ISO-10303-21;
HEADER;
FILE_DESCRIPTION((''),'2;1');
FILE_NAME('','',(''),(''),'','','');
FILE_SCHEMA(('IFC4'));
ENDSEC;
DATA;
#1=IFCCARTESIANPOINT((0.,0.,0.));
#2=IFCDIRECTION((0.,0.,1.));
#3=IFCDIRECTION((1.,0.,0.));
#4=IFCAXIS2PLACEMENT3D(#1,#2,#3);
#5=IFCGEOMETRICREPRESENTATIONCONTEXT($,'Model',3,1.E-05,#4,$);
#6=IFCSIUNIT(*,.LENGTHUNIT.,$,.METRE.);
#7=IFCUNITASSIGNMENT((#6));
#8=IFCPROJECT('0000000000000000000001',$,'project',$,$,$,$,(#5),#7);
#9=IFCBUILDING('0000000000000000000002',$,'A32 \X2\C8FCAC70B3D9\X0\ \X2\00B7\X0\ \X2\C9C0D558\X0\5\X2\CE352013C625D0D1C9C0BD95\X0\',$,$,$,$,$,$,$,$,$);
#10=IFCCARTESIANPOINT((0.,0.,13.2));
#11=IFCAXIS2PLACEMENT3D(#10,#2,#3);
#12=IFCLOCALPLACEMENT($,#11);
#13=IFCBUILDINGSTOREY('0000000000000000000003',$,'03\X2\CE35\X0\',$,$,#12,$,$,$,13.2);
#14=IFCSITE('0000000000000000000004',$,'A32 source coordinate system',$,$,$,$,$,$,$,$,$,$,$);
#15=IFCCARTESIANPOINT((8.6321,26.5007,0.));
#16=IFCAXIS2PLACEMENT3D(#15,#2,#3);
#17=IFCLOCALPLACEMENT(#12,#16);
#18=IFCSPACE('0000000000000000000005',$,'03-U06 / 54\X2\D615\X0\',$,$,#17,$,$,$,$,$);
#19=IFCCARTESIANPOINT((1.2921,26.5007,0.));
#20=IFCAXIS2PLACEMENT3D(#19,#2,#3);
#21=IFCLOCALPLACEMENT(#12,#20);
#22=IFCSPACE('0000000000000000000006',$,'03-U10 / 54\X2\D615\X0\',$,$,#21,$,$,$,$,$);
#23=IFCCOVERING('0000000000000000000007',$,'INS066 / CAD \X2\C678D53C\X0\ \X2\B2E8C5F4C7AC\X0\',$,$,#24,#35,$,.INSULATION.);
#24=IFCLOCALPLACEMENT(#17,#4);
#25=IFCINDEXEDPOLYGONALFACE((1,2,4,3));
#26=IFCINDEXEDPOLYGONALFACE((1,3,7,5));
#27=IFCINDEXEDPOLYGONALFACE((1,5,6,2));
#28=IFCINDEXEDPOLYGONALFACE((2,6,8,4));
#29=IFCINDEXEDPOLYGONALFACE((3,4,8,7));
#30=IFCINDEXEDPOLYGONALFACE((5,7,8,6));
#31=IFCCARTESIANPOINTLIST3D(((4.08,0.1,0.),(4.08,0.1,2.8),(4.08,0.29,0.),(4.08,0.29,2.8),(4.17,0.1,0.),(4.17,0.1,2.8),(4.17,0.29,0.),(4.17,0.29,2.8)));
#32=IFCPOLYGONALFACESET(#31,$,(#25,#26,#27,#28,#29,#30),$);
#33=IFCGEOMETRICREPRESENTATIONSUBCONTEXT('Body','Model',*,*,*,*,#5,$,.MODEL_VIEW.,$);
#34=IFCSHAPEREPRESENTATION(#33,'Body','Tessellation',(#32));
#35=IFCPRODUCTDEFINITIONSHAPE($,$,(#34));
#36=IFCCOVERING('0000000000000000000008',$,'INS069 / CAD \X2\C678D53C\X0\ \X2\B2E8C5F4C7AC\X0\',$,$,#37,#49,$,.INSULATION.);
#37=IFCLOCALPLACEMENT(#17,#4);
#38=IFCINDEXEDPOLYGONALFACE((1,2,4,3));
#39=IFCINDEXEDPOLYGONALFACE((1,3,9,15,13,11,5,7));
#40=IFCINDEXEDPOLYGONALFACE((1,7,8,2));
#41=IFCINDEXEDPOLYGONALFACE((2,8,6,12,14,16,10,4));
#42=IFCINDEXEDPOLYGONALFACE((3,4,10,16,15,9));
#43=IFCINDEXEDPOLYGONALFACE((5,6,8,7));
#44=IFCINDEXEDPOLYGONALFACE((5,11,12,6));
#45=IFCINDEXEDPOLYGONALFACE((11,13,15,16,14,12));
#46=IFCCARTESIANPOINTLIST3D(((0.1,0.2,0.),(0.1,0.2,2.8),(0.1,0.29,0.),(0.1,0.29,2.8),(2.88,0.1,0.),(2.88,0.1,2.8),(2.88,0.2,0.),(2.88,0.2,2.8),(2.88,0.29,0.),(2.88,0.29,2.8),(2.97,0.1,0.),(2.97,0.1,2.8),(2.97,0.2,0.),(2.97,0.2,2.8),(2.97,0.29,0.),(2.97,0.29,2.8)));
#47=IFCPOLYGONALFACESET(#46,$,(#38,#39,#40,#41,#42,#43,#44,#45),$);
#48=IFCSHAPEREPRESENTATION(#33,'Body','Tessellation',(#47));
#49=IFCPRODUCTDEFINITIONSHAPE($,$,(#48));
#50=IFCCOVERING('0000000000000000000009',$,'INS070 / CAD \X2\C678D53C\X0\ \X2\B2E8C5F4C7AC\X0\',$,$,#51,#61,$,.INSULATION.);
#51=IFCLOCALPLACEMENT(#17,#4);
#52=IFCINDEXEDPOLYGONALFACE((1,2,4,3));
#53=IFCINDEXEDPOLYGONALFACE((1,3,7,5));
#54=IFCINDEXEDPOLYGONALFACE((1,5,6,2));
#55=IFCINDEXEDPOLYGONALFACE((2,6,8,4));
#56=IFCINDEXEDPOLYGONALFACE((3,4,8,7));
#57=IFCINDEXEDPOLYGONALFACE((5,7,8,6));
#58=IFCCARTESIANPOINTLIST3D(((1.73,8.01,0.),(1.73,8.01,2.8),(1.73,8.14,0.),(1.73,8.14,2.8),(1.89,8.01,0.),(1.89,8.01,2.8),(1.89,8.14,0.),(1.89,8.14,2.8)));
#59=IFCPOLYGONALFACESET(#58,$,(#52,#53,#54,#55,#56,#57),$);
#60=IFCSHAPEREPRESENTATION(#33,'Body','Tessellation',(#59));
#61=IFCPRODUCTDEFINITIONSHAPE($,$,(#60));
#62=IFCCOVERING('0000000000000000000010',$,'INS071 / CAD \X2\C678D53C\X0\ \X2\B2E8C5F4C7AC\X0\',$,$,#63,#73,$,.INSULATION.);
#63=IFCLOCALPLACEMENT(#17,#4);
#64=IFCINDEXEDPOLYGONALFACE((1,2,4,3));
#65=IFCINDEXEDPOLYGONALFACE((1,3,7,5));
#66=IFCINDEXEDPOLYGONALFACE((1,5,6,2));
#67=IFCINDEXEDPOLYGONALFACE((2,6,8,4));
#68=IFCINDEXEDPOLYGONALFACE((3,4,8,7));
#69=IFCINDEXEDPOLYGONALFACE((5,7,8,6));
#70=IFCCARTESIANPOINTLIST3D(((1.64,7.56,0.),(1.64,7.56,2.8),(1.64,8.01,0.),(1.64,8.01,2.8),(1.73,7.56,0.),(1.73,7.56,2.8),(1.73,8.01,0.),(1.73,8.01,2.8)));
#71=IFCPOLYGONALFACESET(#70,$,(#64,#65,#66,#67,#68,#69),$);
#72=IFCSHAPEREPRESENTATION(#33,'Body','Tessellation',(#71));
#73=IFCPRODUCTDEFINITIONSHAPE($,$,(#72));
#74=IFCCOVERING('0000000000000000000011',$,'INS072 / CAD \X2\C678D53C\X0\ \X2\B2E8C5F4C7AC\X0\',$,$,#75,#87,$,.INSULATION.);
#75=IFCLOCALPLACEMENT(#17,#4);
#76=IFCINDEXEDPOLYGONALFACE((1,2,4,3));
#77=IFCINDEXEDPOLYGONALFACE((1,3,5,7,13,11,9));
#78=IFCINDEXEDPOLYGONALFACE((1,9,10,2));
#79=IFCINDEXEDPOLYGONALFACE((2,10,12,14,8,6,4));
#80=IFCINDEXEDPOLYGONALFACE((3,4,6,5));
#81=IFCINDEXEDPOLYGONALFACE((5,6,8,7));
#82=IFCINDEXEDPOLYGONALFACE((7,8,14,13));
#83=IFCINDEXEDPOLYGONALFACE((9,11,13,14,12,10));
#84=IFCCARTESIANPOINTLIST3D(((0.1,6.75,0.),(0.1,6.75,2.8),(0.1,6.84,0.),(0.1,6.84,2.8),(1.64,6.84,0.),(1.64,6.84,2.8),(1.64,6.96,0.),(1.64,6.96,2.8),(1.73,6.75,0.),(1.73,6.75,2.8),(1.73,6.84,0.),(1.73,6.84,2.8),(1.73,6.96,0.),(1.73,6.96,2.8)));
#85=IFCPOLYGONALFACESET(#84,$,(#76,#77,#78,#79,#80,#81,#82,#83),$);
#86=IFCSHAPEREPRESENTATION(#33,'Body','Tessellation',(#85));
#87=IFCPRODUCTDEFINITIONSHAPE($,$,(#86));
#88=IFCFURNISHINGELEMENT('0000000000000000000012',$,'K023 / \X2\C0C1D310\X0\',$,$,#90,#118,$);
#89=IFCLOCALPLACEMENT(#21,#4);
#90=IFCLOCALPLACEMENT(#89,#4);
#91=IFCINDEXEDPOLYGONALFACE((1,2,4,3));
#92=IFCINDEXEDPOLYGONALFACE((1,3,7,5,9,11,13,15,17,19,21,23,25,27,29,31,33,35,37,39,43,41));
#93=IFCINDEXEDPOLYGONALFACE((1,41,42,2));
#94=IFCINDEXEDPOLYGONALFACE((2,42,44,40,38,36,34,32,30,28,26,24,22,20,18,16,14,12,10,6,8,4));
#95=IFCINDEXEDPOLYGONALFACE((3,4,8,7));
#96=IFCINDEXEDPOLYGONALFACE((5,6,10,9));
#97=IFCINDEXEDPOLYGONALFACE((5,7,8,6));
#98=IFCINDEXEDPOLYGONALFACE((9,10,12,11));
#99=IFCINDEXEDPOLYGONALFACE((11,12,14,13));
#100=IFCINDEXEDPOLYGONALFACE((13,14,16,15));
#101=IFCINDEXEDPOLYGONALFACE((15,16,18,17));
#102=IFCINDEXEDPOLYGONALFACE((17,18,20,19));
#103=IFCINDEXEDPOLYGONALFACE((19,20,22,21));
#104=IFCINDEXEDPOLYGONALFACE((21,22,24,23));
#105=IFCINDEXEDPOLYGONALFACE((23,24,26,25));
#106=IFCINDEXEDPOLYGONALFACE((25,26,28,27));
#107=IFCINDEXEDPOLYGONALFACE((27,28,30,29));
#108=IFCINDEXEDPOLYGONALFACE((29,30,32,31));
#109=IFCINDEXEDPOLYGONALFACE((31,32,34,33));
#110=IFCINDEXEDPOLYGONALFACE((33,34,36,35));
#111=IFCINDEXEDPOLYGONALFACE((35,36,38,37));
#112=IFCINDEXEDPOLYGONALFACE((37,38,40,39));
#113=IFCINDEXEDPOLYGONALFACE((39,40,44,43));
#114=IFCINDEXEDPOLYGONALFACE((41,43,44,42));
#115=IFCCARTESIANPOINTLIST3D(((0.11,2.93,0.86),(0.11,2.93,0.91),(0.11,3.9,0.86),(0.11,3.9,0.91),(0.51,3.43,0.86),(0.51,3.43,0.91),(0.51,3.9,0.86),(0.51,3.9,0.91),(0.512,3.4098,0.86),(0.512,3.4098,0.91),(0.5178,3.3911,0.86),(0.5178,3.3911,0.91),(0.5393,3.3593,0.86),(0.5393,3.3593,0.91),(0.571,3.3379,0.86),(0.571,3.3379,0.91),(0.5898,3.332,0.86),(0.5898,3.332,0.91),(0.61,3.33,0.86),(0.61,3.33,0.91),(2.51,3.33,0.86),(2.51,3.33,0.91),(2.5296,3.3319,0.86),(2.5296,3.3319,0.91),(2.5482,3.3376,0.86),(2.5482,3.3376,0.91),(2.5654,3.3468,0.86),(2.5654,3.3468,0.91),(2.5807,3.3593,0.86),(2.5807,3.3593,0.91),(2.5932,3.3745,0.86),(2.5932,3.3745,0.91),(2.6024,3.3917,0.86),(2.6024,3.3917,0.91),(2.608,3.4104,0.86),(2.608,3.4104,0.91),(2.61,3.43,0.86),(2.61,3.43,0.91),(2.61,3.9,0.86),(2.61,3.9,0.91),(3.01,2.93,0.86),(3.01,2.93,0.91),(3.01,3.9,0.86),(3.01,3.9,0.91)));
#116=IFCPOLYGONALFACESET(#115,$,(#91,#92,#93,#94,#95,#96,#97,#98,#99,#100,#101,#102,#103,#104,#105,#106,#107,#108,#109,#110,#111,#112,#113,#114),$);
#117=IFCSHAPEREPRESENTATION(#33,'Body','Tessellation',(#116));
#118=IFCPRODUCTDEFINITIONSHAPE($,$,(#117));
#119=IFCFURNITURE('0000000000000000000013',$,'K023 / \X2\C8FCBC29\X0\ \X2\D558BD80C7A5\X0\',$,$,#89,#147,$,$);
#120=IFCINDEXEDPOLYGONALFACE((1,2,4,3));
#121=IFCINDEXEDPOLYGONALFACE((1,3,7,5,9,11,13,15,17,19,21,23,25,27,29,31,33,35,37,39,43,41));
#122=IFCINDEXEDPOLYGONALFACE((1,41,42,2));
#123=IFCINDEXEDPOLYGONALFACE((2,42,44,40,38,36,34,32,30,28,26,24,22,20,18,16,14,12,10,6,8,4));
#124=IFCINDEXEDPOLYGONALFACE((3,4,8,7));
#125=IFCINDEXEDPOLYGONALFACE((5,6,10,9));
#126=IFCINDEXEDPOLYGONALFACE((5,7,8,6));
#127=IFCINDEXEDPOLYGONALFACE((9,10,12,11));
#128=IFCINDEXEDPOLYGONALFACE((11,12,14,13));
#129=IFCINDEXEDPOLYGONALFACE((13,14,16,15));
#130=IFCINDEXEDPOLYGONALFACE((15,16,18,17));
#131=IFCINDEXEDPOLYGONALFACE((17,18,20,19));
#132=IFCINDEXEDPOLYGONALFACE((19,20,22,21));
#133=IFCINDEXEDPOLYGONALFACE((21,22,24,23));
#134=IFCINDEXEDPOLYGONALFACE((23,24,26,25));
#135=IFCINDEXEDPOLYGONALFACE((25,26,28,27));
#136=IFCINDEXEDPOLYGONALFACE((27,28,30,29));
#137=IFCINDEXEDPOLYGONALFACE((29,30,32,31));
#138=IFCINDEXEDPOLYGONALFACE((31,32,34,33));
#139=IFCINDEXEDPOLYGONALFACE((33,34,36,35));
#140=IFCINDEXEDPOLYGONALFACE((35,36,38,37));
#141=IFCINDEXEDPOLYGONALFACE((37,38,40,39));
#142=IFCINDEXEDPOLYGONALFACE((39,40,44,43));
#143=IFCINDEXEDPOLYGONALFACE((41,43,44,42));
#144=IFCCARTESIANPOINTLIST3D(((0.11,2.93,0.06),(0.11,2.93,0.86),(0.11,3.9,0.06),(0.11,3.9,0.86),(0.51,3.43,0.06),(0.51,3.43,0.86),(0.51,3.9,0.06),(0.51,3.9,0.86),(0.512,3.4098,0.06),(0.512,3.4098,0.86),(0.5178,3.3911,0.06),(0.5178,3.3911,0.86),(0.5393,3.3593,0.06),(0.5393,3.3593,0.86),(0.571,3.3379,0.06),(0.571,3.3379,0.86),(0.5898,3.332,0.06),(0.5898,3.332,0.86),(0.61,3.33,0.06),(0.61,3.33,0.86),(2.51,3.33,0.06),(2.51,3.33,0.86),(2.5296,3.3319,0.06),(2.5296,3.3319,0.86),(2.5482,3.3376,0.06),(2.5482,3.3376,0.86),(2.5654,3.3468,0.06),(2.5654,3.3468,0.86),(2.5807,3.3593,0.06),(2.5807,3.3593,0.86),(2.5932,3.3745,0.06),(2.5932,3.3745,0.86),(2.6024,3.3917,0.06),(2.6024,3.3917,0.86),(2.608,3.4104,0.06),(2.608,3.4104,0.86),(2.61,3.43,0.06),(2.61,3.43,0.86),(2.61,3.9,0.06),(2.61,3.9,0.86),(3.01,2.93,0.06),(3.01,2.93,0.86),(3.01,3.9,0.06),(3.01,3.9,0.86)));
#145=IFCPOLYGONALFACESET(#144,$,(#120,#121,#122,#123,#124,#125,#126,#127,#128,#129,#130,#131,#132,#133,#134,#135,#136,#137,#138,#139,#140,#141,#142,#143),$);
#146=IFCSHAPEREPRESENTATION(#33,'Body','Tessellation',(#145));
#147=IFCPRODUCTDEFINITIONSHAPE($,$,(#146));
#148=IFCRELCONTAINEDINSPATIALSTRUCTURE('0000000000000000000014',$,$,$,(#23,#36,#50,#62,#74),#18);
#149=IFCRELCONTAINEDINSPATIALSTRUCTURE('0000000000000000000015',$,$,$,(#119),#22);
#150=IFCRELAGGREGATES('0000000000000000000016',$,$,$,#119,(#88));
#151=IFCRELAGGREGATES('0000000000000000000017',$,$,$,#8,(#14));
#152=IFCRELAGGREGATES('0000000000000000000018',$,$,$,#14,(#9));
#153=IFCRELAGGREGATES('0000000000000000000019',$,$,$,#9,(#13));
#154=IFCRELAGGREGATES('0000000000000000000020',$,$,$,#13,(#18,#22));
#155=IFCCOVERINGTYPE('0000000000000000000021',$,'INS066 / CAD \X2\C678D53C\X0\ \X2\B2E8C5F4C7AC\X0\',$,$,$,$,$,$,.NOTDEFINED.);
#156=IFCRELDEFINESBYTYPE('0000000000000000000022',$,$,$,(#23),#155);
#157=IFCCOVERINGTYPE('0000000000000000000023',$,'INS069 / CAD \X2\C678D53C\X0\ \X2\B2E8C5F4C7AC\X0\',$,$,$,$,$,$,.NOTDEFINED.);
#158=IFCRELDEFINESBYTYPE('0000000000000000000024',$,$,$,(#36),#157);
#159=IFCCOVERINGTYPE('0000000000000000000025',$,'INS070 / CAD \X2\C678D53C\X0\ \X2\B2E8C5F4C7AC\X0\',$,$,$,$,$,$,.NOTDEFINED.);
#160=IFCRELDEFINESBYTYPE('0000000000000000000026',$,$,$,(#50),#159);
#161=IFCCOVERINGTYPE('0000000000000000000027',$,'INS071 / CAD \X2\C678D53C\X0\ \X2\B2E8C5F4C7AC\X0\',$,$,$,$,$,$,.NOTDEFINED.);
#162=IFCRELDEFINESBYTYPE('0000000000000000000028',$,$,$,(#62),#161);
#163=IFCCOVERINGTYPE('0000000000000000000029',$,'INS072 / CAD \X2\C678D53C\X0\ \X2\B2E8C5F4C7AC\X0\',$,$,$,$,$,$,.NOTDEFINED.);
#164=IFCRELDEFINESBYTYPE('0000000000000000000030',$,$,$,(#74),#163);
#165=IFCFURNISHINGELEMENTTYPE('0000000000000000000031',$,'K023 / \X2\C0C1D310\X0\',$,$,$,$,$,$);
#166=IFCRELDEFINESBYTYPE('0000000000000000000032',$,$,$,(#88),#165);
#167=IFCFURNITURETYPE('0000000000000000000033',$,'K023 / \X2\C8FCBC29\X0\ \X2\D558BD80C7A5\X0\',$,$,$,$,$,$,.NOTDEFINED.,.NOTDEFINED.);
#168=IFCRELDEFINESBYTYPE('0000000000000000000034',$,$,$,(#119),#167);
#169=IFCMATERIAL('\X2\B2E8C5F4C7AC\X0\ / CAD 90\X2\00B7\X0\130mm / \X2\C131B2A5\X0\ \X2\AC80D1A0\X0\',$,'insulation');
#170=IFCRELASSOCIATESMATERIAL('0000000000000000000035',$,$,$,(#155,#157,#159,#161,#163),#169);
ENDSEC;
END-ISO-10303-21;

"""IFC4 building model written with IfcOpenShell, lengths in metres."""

from ifc_helpers import new_model, si_unit, frame, origin, origin_with_axes, place, context, subcontext, project, spatial, polyline, outline, extrude, source, transform, mapped, material, type_object, type_shapes, element, aggregate, save


model = new_model("IFC4")

# Units and contexts
model_context = context("Model", 3, precision=1e-05, world=origin_with_axes())
body_context = subcontext(model_context, "Body", "Model", "MODEL_VIEW")
ifc_project = project(units=[si_unit("LENGTHUNIT", "METRE")], contexts=[model_context])

# Site, building, storey, space
storey_placement = place(None, frame((0.0, 0.0, 13.2), z_axis=(0.0, 0.0, 1.0), x_axis=(1.0, 0.0, 0.0)))
space_1_placement = place(storey_placement, frame((8.6321, 26.5007, 0.0), z_axis=(0.0, 0.0, 1.0), x_axis=(1.0, 0.0, 0.0)))
site = spatial("IfcSite", under=ifc_project, Name="A32 source coordinate system")
building = spatial("IfcBuilding", under=site, Name="A32 주거동 · 지하5층–옥탑지붕")
storey = spatial("IfcBuildingStorey", under=building, at=storey_placement, Name="03층", Elevation=13.2)
space_1 = spatial("IfcSpace", under=storey, at=space_1_placement, Name="03-U06 / 54형")

# Shared definitions
space_2_placement = place(storey_placement, frame((1.2921, 26.5007, 0.0), z_axis=(0.0, 0.0, 1.0), x_axis=(1.0, 0.0, 0.0)))
space_2 = spatial("IfcSpace", under=storey, at=space_2_placement, Name="03-U10 / 54형")

# Coverings
ifc_material = material(Name="단열재 / CAD 90·130mm / 성능 검토", Category="insulation")
covering_type_1 = type_object("IfcCoveringType", Name="INS066 / CAD 외피 단열재", PredefinedType="NOTDEFINED", material=ifc_material)
shared_shape_1 = source(origin(), body_context, "Body", "SweptSolid", [
    extrude(outline(polyline([(4.08, 0.29), (4.17, 0.29), (4.17, 0.1), (4.08, 0.1), (4.08, 0.29)])), origin(), (0.0, 0.0, 1.0), 2.8),
])
type_shapes(covering_type_1, [shared_shape_1])
covering_1_placement = place(space_1_placement, origin_with_axes())
element("IfcCovering", 1, at=covering_1_placement, inside=space_1, type_object=covering_type_1, Name="INS066 / CAD 외피 단열재", PredefinedType="INSULATION", context=body_context, shape_type="MappedRepresentation", body=[
    mapped(shared_shape_1, transform((0.0, 0.0, 0.0), scale=1.0)),
])
covering_type_2 = type_object("IfcCoveringType", Name="INS069 / CAD 외피 단열재", PredefinedType="NOTDEFINED", material=ifc_material)
shared_shape_2 = source(origin(), body_context, "Body", "SweptSolid", [
    extrude(outline(polyline([(2.97, 0.1), (2.88, 0.1), (2.88, 0.2), (0.1, 0.2), (0.1, 0.29), (2.88, 0.29), (2.97, 0.29), (2.97, 0.2), (2.97, 0.1)])), origin(), (0.0, 0.0, 1.0), 2.8),
])
type_shapes(covering_type_2, [shared_shape_2])
covering_2_placement = place(space_1_placement, origin_with_axes())
element("IfcCovering", 2, at=covering_2_placement, inside=space_1, type_object=covering_type_2, Name="INS069 / CAD 외피 단열재", PredefinedType="INSULATION", context=body_context, shape_type="MappedRepresentation", body=[
    mapped(shared_shape_2, transform((0.0, 0.0, 0.0), scale=1.0)),
])
covering_type_3 = type_object("IfcCoveringType", Name="INS070 / CAD 외피 단열재", PredefinedType="NOTDEFINED", material=ifc_material)
shared_shape_3 = source(origin(), body_context, "Body", "SweptSolid", [
    extrude(outline(polyline([(1.73, 8.14), (1.89, 8.14), (1.89, 8.01), (1.73, 8.01), (1.73, 8.14)])), origin(), (0.0, 0.0, 1.0), 2.8),
])
type_shapes(covering_type_3, [shared_shape_3])
covering_3_placement = place(space_1_placement, origin_with_axes())
element("IfcCovering", 3, at=covering_3_placement, inside=space_1, type_object=covering_type_3, Name="INS070 / CAD 외피 단열재", PredefinedType="INSULATION", context=body_context, shape_type="MappedRepresentation", body=[
    mapped(shared_shape_3, transform((0.0, 0.0, 0.0), scale=1.0)),
])
covering_type_4 = type_object("IfcCoveringType", Name="INS071 / CAD 외피 단열재", PredefinedType="NOTDEFINED", material=ifc_material)
shared_shape_4 = source(origin(), body_context, "Body", "SweptSolid", [
    extrude(outline(polyline([(1.73, 7.56), (1.64, 7.56), (1.64, 8.01), (1.73, 8.01), (1.73, 7.56)])), origin(), (0.0, 0.0, 1.0), 2.8),
])
type_shapes(covering_type_4, [shared_shape_4])
covering_4_placement = place(space_1_placement, origin_with_axes())
element("IfcCovering", 4, at=covering_4_placement, inside=space_1, type_object=covering_type_4, Name="INS071 / CAD 외피 단열재", PredefinedType="INSULATION", context=body_context, shape_type="MappedRepresentation", body=[
    mapped(shared_shape_4, transform((0.0, 0.0, 0.0), scale=1.0)),
])
covering_type_5 = type_object("IfcCoveringType", Name="INS072 / CAD 외피 단열재", PredefinedType="NOTDEFINED", material=ifc_material)
shared_shape_5 = source(origin(), body_context, "Body", "SweptSolid", [
    extrude(outline(polyline([(1.64, 6.84), (1.64, 6.96), (1.73, 6.96), (1.73, 6.84), (1.73, 6.75), (0.1, 6.75), (0.1, 6.84), (1.64, 6.84)])), origin(), (0.0, 0.0, 1.0), 2.8),
])
type_shapes(covering_type_5, [shared_shape_5])
covering_5_placement = place(space_1_placement, origin_with_axes())
element("IfcCovering", 5, at=covering_5_placement, inside=space_1, type_object=covering_type_5, Name="INS072 / CAD 외피 단열재", PredefinedType="INSULATION", context=body_context, shape_type="MappedRepresentation", body=[
    mapped(shared_shape_5, transform((0.0, 0.0, 0.0), scale=1.0)),
])

# Furnishing element
furnishing_element_type_1 = type_object("IfcFurnishingElementType", Name="K023 / 상판")
shared_shape_6 = source(origin(), body_context, "Body", "SweptSolid", [
    extrude(outline(polyline([(0.51, 3.43), (0.512, 3.4098), (0.5178, 3.3911), (0.5393, 3.3593), (0.571, 3.3379), (0.5898, 3.332), (0.61, 3.33), (2.51, 3.33), (2.5296, 3.3319), (2.5482, 3.3376), (2.5654, 3.3468), (2.5807, 3.3593), (2.5932, 3.3745), (2.6024, 3.3917), (2.608, 3.4104), (2.61, 3.43), (2.61, 3.9), (3.01, 3.9), (3.01, 2.93), (0.11, 2.93), (0.11, 3.9), (0.51, 3.9), (0.51, 3.43)])), frame((0.0, 0.0, 0.86)), (0.0, 0.0, 1.0), 0.05),
])
type_shapes(furnishing_element_type_1, [shared_shape_6])
furniture_1_placement = place(space_2_placement, origin_with_axes())
furnishing_1_placement = place(furniture_1_placement, origin_with_axes())
furnishing_1 = element("IfcFurnishingElement", 6, at=furnishing_1_placement, type_object=furnishing_element_type_1, Name="K023 / 상판", context=body_context, shape_type="MappedRepresentation", body=[
    mapped(shared_shape_6, transform((0.0, 0.0, 0.0), scale=1.0)),
])

# Furniture
furniture_type_1 = type_object("IfcFurnitureType", Name="K023 / 주방 하부장", AssemblyPlace="NOTDEFINED", PredefinedType="NOTDEFINED")
shared_shape_7 = source(origin(), body_context, "Body", "SweptSolid", [
    extrude(outline(polyline([(0.51, 3.9), (0.51, 3.43), (0.512, 3.4098), (0.5178, 3.3911), (0.5393, 3.3593), (0.571, 3.3379), (0.5898, 3.332), (0.61, 3.33), (2.51, 3.33), (2.5296, 3.3319), (2.5482, 3.3376), (2.5654, 3.3468), (2.5807, 3.3593), (2.5932, 3.3745), (2.6024, 3.3917), (2.608, 3.4104), (2.61, 3.43), (2.61, 3.9), (3.01, 3.9), (3.01, 2.93), (0.11, 2.93), (0.11, 3.9), (0.51, 3.9)])), frame((0.0, 0.0, 0.06)), (0.0, 0.0, 1.0), 0.8),
])
type_shapes(furniture_type_1, [shared_shape_7])
furniture_1 = element("IfcFurniture", 7, at=furniture_1_placement, inside=space_2, type_object=furniture_type_1, Name="K023 / 주방 하부장", context=body_context, shape_type="MappedRepresentation", body=[
    mapped(shared_shape_7, transform((0.0, 0.0, 0.0), scale=1.0)),
])
aggregate(furniture_1, [furnishing_1])

save(model, "model.ifc")
